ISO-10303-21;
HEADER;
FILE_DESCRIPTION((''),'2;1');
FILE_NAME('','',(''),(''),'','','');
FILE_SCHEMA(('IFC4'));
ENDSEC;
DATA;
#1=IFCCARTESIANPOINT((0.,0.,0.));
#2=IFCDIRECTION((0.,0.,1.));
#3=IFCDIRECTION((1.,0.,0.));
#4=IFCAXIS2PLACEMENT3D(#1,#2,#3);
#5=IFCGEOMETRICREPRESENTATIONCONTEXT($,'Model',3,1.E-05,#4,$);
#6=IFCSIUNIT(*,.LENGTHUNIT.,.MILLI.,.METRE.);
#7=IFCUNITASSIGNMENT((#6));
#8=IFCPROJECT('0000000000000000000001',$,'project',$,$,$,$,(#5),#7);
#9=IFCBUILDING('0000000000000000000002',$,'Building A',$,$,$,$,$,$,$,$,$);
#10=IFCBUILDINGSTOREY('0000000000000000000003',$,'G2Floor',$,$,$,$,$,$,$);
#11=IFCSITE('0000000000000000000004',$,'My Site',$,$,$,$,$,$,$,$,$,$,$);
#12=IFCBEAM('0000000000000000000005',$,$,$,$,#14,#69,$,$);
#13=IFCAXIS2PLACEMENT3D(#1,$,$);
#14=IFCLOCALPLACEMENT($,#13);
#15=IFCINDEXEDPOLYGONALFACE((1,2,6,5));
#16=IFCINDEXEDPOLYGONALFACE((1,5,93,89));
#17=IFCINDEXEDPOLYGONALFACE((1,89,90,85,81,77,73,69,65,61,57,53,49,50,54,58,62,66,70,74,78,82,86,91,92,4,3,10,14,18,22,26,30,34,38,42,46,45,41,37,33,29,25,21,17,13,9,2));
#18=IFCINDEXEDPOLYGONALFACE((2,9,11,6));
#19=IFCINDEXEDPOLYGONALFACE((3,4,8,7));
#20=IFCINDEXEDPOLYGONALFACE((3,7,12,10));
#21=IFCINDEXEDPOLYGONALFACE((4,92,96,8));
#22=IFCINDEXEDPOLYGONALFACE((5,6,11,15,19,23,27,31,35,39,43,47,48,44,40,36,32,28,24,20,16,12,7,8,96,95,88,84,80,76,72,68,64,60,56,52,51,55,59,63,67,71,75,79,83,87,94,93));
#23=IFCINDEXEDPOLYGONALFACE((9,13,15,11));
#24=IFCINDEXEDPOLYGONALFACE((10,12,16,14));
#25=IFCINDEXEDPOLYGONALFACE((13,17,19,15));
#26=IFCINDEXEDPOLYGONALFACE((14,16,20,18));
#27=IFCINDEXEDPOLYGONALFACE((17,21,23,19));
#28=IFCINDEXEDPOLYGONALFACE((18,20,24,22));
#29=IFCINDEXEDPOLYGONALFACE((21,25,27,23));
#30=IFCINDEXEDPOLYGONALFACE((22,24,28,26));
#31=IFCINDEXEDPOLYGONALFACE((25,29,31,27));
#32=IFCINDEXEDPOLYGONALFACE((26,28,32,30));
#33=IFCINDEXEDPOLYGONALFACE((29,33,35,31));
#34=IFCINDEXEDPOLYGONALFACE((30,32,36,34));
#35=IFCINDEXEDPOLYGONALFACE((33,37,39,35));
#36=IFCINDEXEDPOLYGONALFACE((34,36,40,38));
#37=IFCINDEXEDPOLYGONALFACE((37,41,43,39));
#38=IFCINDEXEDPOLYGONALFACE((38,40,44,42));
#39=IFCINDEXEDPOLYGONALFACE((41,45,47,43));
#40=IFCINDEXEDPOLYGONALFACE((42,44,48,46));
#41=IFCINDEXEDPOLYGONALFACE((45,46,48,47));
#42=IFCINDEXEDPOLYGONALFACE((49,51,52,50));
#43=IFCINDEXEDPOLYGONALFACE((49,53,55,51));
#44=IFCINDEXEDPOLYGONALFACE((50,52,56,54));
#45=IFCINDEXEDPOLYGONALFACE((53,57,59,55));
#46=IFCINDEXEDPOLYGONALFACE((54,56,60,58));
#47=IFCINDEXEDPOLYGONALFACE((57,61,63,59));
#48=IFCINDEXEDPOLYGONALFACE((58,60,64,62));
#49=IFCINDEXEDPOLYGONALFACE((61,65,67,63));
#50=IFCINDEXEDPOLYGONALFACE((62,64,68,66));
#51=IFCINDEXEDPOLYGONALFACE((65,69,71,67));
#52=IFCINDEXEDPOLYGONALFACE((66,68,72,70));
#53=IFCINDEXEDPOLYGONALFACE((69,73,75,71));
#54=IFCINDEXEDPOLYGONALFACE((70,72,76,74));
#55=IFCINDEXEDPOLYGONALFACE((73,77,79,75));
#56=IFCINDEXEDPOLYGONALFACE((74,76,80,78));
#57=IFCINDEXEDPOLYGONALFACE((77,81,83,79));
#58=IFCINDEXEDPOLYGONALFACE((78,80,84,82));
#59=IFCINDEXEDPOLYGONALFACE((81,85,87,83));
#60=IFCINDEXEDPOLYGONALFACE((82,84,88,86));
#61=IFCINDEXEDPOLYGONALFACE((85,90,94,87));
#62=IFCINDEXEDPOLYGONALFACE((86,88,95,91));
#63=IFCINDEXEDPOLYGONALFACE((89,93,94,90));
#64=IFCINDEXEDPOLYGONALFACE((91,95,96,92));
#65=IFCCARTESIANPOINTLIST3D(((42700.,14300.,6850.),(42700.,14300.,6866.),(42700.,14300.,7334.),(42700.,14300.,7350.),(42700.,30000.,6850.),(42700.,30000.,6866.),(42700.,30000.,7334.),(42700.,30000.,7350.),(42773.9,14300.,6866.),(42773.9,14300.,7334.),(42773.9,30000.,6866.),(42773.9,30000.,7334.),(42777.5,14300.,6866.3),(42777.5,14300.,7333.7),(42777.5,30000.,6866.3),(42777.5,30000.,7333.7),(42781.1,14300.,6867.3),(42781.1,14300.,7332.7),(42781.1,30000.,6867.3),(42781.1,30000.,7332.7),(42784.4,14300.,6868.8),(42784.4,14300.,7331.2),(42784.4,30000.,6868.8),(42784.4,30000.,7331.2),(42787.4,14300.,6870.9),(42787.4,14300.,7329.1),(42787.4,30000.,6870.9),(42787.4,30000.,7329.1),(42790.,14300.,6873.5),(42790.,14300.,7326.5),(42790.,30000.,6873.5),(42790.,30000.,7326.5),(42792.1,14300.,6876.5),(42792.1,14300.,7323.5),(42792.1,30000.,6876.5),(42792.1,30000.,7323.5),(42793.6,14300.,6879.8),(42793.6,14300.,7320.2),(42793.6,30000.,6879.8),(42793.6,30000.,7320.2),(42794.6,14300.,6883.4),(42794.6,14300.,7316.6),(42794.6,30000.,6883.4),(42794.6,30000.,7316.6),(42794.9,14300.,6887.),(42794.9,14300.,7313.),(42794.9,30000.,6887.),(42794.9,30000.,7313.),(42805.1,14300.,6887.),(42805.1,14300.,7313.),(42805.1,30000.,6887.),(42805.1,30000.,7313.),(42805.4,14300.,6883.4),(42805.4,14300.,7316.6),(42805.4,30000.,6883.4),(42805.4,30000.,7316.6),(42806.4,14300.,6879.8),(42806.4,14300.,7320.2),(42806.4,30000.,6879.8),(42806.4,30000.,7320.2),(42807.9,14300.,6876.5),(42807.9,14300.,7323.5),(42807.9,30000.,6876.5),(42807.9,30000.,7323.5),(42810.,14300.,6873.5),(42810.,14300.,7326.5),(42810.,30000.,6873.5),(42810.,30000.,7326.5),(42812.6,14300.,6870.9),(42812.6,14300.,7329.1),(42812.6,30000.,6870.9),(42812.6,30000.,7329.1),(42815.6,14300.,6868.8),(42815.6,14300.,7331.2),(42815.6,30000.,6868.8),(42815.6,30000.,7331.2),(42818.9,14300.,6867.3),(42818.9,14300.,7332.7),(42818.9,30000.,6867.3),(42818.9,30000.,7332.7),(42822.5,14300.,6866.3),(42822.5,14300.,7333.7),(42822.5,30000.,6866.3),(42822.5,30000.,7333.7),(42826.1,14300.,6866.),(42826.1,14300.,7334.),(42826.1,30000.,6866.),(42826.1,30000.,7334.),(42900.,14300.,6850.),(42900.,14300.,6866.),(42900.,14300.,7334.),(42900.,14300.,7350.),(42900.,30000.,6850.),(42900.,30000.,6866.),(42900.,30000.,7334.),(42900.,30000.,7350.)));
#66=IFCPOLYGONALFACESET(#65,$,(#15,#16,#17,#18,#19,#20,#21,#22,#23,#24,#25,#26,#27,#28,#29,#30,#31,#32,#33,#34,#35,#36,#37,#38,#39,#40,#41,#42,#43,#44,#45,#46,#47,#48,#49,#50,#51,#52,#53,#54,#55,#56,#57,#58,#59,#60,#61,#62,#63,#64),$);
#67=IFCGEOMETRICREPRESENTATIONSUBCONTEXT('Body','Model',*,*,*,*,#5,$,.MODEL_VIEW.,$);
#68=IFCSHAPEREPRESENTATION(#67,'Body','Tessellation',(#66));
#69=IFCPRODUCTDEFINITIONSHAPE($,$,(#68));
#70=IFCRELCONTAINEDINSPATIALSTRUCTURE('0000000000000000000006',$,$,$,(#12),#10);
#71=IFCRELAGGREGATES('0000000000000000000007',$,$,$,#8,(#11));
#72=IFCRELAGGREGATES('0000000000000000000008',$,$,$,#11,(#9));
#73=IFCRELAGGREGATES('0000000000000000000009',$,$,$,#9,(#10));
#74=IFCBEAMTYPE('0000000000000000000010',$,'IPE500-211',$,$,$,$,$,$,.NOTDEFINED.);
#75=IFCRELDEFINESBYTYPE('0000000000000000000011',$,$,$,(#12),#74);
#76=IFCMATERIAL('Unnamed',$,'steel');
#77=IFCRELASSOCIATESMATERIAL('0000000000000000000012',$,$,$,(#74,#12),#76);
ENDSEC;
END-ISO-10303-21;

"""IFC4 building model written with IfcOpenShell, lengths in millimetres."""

from ifc_helpers import new_model, si_unit, frame, origin_with_axes, place, context, subcontext, project, spatial, polyline, outline, extrude, material, material_profile, profile_set, profile_usage, type_object, element, save


model = new_model("IFC4")

# Units and contexts
model_context = context("Model", 3, precision=1e-05, world=origin_with_axes())
body_context = subcontext(model_context, "Body", "Model", "MODEL_VIEW")
ifc_project = project(units=[si_unit("LENGTHUNIT", "METRE", prefix="MILLI")], contexts=[model_context])

# Site, building, storey
site = spatial("IfcSite", under=ifc_project, Name="My Site")
building = spatial("IfcBuilding", under=site, Name="Building A")
storey = spatial("IfcBuildingStorey", under=building, Name="G2Floor")

# Beam
ifc_material_1 = material(Name="Unnamed", Category="steel")
ifc_material_profile_1 = material_profile(ifc_material_1, outline(polyline([(100.0, -250.0), (100.0, -234.0), (100.0, -234.0), (26.1, -234.0), (26.1, -234.0), (22.5, -233.7), (22.5, -233.7), (18.9, -232.7), (18.9, -232.7), (15.6, -231.2), (15.6, -231.2), (12.6, -229.1), (12.6, -229.1), (10.0, -226.5), (10.0, -226.5), (7.9, -223.5), (7.9, -223.5), (6.4, -220.2), (6.4, -220.2), (5.4, -216.6), (5.4, -216.6), (5.1, -213.0), (5.1, -213.0), (5.1, 213.0), (5.1, 213.0), (5.4, 216.6), (5.4, 216.6), (6.4, 220.2), (6.4, 220.2), (7.9, 223.5), (7.9, 223.5), (10.0, 226.5), (10.0, 226.5), (12.6, 229.1), (12.6, 229.1), (15.6, 231.2), (15.6, 231.2), (18.9, 232.7), (18.9, 232.7), (22.5, 233.7), (22.5, 233.7), (26.1, 234.0), (26.1, 234.0), (100.0, 234.0), (100.0, 234.0), (100.0, 250.0), (100.0, 250.0), (-100.0, 250.0), (-100.0, 250.0), (-100.0, 234.0), (-100.0, 234.0), (-26.1, 234.0), (-26.1, 234.0), (-22.5, 233.7), (-22.5, 233.7), (-18.9, 232.7), (-18.9, 232.7), (-15.6, 231.2), (-15.6, 231.2), (-12.6, 229.1), (-12.6, 229.1), (-10.0, 226.5), (-10.0, 226.5), (-7.9, 223.5), (-7.9, 223.5), (-6.4, 220.2), (-6.4, 220.2), (-5.4, 216.6), (-5.4, 216.6), (-5.1, 213.0), (-5.1, 213.0), (-5.1, -213.0), (-5.1, -213.0), (-5.4, -216.6), (-5.4, -216.6), (-6.4, -220.2), (-6.4, -220.2), (-7.9, -223.5), (-7.9, -223.5), (-10.0, -226.5), (-10.0, -226.5), (-12.6, -229.1), (-12.6, -229.1), (-15.6, -231.2), (-15.6, -231.2), (-18.9, -232.7), (-18.9, -232.7), (-22.5, -233.7), (-22.5, -233.7), (-26.1, -234.0), (-26.1, -234.0), (-100.0, -234.0), (-100.0, -234.0), (-100.0, -250.0), (-100.0, -250.0), (100.0, -250.0)])))
ifc_profile_set_1 = profile_set([ifc_material_profile_1], Name="IPE500-211")
ifc_profile_usage_1 = profile_usage(ifc_profile_set_1)
beam_type_1 = type_object("IfcBeamType", Name="IPE500-211", PredefinedType="NOTDEFINED", material=ifc_profile_set_1)
beam_1_placement = place(None, frame((42800.0, 14300.0, 7100.0), z_axis=(0.0, 1.0, 0.0), x_axis=(1.0, 0.0, 0.0)))
element("IfcBeam", 1, at=beam_1_placement, inside=storey, type_object=beam_type_1, material=ifc_profile_usage_1, context=body_context, shape_type="SweptSolid", body=[
    extrude(outline(polyline([(100.0, -250.0), (100.0, -234.0), (100.0, -234.0), (26.1, -234.0), (26.1, -234.0), (22.5, -233.7), (22.5, -233.7), (18.9, -232.7), (18.9, -232.7), (15.6, -231.2), (15.6, -231.2), (12.6, -229.1), (12.6, -229.1), (10.0, -226.5), (10.0, -226.5), (7.9, -223.5), (7.9, -223.5), (6.4, -220.2), (6.4, -220.2), (5.4, -216.6), (5.4, -216.6), (5.1, -213.0), (5.1, -213.0), (5.1, 213.0), (5.1, 213.0), (5.4, 216.6), (5.4, 216.6), (6.4, 220.2), (6.4, 220.2), (7.9, 223.5), (7.9, 223.5), (10.0, 226.5), (10.0, 226.5), (12.6, 229.1), (12.6, 229.1), (15.6, 231.2), (15.6, 231.2), (18.9, 232.7), (18.9, 232.7), (22.5, 233.7), (22.5, 233.7), (26.1, 234.0), (26.1, 234.0), (100.0, 234.0), (100.0, 234.0), (100.0, 250.0), (100.0, 250.0), (-100.0, 250.0), (-100.0, 250.0), (-100.0, 234.0), (-100.0, 234.0), (-26.1, 234.0), (-26.1, 234.0), (-22.5, 233.7), (-22.5, 233.7), (-18.9, 232.7), (-18.9, 232.7), (-15.6, 231.2), (-15.6, 231.2), (-12.6, 229.1), (-12.6, 229.1), (-10.0, 226.5), (-10.0, 226.5), (-7.9, 223.5), (-7.9, 223.5), (-6.4, 220.2), (-6.4, 220.2), (-5.4, 216.6), (-5.4, 216.6), (-5.1, 213.0), (-5.1, 213.0), (-5.1, -213.0), (-5.1, -213.0), (-5.4, -216.6), (-5.4, -216.6), (-6.4, -220.2), (-6.4, -220.2), (-7.9, -223.5), (-7.9, -223.5), (-10.0, -226.5), (-10.0, -226.5), (-12.6, -229.1), (-12.6, -229.1), (-15.6, -231.2), (-15.6, -231.2), (-18.9, -232.7), (-18.9, -232.7), (-22.5, -233.7), (-22.5, -233.7), (-26.1, -234.0), (-26.1, -234.0), (-100.0, -234.0), (-100.0, -234.0), (-100.0, -250.0), (-100.0, -250.0), (100.0, -250.0)])), origin_with_axes(), (0.0, 0.0, 1.0), 15700.0),
])

save(model, "model.ifc")
